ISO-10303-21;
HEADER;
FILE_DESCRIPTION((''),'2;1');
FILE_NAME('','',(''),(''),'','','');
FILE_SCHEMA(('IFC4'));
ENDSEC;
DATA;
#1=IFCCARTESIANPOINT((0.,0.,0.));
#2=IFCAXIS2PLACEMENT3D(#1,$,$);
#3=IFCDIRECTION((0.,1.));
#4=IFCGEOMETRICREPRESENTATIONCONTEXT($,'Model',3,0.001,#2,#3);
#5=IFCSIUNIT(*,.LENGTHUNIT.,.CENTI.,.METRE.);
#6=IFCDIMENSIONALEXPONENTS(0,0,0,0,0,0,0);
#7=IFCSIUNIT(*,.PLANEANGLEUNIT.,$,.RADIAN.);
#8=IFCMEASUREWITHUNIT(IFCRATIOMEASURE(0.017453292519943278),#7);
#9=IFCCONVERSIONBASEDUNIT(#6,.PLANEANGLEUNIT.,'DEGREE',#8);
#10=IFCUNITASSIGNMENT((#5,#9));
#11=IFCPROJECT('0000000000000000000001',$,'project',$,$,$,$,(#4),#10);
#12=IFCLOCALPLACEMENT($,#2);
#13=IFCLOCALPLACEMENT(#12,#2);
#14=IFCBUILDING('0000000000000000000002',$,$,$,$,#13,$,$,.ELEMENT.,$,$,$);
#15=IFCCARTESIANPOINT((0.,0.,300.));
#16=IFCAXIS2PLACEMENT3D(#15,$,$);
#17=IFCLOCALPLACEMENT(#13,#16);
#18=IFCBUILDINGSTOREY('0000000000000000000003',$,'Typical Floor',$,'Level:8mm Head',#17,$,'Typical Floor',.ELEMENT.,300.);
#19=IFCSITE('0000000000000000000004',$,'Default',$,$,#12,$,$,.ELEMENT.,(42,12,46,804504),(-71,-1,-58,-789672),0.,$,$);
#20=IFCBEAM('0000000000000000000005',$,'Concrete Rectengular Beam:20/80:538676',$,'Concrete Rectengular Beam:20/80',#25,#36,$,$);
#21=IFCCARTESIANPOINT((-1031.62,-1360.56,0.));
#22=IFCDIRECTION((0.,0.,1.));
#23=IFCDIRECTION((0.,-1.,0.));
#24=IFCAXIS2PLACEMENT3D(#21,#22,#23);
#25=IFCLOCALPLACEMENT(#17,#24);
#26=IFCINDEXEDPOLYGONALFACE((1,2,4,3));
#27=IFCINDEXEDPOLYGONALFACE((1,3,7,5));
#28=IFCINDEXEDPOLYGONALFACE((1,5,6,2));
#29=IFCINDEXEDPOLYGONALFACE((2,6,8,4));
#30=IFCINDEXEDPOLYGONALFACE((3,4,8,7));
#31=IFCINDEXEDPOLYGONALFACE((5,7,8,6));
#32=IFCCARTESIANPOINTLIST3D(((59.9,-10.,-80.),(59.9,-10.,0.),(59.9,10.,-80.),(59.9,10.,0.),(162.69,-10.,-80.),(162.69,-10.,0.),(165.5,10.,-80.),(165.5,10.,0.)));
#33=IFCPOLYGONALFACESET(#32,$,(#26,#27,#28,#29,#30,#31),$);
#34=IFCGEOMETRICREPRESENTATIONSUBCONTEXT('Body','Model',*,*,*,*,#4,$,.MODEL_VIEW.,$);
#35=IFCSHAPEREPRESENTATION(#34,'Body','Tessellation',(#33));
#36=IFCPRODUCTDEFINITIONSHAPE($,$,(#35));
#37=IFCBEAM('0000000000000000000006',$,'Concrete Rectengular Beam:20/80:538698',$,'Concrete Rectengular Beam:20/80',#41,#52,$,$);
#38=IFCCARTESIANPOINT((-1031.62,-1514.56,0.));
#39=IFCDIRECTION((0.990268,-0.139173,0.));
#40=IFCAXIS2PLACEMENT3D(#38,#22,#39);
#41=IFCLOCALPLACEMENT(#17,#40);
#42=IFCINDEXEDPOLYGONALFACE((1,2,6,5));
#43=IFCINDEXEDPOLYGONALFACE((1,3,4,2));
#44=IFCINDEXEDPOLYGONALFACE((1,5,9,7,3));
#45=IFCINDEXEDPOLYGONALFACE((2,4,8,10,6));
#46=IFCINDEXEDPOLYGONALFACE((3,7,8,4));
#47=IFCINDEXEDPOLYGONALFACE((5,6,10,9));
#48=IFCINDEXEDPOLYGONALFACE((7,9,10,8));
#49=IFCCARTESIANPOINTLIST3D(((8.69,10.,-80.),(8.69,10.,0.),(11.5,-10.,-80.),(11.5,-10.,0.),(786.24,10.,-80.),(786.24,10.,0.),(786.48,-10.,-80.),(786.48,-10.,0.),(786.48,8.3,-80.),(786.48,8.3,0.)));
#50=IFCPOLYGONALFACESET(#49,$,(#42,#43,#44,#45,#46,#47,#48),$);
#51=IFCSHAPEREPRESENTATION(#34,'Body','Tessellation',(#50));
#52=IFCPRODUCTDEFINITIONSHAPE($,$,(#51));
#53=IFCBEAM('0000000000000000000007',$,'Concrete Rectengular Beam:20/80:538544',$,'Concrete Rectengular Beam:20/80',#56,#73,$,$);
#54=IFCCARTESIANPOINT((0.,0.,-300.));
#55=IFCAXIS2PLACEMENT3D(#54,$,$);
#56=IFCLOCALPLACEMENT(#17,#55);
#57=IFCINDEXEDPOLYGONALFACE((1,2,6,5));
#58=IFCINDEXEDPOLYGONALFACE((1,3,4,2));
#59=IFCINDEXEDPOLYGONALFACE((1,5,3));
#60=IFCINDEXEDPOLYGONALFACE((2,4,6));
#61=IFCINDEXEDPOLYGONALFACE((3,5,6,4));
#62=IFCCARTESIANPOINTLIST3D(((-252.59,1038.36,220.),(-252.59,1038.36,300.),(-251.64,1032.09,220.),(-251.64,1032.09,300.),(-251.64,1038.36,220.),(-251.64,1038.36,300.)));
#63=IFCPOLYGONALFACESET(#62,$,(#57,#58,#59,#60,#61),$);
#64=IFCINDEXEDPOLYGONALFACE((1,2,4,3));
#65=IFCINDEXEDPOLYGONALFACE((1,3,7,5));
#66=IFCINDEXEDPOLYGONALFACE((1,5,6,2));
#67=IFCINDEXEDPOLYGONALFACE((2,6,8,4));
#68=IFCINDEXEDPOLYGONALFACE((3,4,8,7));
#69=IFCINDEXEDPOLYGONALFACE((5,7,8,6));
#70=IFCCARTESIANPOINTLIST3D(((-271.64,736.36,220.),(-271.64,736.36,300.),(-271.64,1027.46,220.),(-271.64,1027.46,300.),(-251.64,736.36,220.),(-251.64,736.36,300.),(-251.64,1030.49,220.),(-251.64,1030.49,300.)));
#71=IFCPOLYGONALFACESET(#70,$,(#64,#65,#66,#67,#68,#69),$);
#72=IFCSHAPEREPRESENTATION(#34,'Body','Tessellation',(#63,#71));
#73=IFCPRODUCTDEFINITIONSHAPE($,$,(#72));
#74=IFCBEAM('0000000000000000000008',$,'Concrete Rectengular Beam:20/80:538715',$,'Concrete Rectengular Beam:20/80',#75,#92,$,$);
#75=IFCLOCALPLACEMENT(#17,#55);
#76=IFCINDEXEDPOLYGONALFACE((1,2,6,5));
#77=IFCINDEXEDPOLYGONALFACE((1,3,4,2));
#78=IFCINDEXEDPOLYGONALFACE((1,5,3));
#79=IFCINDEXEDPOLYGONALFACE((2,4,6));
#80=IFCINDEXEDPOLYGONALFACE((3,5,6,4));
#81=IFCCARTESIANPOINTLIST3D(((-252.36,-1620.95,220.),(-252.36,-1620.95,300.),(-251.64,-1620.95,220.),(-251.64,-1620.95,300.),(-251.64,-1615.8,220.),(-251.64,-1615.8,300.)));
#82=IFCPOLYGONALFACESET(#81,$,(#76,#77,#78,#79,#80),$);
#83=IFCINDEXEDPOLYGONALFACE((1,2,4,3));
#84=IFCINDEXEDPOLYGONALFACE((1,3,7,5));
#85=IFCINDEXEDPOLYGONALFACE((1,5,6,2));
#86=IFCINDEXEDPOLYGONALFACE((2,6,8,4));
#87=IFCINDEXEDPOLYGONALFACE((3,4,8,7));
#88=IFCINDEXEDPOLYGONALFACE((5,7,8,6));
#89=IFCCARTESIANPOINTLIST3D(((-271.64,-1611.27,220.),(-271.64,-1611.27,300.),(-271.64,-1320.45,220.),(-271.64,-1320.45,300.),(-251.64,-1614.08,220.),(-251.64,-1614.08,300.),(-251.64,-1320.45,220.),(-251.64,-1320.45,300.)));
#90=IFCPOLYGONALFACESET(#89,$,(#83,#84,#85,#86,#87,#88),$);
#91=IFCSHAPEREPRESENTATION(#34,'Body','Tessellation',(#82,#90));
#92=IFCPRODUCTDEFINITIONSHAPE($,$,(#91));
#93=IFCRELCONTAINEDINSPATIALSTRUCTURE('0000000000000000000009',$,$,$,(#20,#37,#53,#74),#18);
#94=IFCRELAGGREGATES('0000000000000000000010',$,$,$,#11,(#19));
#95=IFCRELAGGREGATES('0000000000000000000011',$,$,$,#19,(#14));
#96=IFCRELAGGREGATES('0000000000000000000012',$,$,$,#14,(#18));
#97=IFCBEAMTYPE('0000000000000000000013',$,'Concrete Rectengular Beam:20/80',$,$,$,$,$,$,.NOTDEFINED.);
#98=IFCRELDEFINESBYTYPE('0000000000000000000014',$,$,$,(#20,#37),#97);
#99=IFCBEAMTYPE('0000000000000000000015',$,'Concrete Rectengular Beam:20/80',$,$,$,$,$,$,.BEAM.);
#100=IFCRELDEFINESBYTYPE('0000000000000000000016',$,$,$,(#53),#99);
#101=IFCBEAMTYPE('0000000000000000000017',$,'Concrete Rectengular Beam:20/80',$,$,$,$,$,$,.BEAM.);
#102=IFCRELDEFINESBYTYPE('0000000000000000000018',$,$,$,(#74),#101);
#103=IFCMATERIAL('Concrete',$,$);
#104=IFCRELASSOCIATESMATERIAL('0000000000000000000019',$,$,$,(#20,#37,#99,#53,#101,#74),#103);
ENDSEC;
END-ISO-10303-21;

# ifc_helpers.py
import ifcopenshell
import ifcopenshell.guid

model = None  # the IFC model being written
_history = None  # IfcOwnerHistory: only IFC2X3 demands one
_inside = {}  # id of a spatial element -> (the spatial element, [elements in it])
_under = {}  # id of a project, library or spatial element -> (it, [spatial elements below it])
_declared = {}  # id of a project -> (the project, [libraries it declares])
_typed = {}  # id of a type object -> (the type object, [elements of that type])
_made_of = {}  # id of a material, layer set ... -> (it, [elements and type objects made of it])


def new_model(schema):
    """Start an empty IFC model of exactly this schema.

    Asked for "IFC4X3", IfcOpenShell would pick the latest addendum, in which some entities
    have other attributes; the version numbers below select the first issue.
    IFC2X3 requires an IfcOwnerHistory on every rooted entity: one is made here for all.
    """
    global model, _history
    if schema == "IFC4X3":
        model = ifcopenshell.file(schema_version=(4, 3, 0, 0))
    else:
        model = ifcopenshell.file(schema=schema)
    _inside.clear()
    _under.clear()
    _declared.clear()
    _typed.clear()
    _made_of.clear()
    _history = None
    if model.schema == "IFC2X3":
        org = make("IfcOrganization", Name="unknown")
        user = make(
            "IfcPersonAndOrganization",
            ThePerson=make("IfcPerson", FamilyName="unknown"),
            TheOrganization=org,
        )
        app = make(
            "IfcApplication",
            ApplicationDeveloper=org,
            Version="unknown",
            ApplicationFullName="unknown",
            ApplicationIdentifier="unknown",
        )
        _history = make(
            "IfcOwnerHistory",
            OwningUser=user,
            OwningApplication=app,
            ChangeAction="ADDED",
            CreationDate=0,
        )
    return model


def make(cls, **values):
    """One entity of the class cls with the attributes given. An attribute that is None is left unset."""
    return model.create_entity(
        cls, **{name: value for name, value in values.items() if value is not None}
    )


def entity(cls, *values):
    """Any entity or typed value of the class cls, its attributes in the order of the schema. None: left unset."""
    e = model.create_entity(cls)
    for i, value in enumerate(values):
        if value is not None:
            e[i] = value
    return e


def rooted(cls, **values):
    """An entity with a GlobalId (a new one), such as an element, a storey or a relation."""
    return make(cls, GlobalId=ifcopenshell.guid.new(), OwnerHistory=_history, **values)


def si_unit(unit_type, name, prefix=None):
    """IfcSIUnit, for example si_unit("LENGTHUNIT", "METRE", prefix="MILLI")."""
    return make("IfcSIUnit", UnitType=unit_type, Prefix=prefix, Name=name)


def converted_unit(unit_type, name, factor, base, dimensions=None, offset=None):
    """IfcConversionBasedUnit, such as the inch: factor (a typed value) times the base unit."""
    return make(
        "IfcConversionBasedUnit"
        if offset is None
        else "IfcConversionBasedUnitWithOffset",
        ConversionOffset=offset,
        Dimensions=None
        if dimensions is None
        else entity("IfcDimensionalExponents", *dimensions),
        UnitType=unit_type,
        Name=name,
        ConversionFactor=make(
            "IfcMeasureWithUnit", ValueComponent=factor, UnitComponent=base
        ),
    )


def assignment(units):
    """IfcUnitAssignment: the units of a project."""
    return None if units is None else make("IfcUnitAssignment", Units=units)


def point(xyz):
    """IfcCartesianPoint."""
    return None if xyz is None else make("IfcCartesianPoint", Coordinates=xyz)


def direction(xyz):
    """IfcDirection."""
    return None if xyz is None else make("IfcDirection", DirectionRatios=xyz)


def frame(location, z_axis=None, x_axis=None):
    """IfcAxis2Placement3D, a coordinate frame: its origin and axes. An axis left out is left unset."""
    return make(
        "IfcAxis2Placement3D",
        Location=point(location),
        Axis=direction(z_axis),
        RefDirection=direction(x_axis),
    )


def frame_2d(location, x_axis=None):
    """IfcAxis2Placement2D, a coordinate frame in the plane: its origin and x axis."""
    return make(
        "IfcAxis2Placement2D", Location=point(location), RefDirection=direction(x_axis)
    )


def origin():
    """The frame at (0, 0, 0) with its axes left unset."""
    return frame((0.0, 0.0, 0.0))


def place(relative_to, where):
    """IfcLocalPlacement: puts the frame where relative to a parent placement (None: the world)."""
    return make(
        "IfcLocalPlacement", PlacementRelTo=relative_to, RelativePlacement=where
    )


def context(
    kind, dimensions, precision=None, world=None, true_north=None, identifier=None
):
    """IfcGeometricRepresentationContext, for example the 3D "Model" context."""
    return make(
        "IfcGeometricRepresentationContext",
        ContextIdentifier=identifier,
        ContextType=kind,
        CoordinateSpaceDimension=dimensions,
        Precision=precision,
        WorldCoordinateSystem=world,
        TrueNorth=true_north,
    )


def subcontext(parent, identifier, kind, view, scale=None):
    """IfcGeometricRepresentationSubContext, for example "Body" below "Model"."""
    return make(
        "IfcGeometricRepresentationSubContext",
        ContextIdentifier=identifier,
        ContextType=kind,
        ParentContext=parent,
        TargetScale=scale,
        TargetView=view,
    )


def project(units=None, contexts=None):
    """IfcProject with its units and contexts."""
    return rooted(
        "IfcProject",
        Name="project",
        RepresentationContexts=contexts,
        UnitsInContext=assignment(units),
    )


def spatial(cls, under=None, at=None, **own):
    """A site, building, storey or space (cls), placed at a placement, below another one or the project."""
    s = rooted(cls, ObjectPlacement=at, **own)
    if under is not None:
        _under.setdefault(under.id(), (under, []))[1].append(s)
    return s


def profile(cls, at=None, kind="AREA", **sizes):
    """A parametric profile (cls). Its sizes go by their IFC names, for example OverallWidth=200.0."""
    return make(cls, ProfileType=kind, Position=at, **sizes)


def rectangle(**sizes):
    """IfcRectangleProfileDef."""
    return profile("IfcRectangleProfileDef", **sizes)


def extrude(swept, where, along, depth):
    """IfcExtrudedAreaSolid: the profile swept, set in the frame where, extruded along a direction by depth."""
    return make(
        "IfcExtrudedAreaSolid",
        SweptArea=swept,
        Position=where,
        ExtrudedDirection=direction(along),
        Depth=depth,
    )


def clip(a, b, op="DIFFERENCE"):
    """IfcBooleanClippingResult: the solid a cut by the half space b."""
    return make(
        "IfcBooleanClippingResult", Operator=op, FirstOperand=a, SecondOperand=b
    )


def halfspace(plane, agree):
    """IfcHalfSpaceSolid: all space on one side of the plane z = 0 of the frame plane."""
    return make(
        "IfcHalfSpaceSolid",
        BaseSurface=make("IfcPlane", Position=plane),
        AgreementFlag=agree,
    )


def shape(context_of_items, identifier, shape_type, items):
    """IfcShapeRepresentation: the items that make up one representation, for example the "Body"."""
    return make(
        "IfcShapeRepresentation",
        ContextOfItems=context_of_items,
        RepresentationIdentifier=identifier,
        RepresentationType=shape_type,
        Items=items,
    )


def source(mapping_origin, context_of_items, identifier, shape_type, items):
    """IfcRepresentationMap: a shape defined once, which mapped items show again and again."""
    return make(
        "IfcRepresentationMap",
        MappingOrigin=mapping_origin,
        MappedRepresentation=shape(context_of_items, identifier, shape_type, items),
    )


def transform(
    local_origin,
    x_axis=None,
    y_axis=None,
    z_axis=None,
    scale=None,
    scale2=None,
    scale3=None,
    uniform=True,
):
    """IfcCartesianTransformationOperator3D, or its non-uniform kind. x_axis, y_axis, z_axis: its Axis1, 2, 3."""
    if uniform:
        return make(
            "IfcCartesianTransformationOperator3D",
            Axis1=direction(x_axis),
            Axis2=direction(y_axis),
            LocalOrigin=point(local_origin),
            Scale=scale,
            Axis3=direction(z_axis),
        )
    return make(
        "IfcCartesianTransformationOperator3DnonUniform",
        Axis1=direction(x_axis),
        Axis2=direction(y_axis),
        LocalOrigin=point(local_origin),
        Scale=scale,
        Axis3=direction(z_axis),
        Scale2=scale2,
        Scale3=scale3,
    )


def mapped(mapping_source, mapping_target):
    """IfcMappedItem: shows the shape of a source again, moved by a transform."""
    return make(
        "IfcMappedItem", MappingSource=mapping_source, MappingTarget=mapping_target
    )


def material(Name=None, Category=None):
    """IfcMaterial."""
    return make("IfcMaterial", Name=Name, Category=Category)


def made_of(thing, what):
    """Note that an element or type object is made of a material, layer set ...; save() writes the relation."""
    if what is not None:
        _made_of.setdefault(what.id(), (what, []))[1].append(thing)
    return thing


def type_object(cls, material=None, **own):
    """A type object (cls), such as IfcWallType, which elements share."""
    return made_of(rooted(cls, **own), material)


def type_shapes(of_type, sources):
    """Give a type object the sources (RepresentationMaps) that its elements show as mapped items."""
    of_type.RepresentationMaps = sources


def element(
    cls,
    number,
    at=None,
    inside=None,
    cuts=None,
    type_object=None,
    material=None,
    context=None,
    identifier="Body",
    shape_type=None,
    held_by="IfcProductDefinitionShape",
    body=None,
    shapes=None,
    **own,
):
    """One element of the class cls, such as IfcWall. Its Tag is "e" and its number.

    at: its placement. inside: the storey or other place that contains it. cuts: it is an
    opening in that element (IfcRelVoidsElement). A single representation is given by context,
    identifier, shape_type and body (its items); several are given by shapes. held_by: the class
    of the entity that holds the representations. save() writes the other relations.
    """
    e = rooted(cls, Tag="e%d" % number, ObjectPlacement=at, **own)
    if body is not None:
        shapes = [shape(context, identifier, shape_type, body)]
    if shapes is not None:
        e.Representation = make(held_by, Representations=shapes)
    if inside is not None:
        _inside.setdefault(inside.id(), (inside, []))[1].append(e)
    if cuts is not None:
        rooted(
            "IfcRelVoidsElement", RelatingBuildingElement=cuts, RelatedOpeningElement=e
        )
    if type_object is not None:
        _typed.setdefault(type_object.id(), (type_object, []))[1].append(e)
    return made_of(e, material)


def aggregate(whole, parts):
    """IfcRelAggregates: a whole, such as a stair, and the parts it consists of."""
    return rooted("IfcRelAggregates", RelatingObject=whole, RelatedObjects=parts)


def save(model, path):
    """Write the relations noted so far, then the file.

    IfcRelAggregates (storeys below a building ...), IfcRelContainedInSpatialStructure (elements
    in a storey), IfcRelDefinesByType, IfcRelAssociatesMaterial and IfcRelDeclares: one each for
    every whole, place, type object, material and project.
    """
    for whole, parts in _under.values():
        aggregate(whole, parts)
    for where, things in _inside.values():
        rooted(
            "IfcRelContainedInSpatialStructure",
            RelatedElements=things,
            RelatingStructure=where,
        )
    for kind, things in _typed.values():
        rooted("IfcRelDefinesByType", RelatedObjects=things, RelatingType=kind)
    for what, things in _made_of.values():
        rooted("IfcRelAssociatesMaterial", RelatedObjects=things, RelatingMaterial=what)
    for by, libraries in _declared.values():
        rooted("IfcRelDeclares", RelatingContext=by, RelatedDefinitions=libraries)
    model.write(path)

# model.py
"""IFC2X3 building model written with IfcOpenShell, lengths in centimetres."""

from ifc_helpers import new_model, entity, si_unit, converted_unit, direction, frame, frame_2d, origin, place, context, subcontext, project, spatial, rectangle, extrude, clip, halfspace, source, transform, mapped, material, type_object, type_shapes, element, save


model = new_model("IFC2X3")

# Units and contexts
model_context = context("Model", 3, precision=0.001, world=origin(), true_north=direction((0.0, 1.0)))
body_context = subcontext(model_context, "Body", "Model", "MODEL_VIEW")
ifc_project = project(units=[si_unit("LENGTHUNIT", "METRE", prefix="CENTI"), converted_unit("PLANEANGLEUNIT", "DEGREE", entity("IfcRatioMeasure", 0.017453292519943278), si_unit("PLANEANGLEUNIT", "RADIAN"), dimensions=[0, 0, 0, 0, 0, 0, 0])], contexts=[model_context])

# Site, building, storey
site_placement = place(None, origin())
site = spatial("IfcSite", under=ifc_project, at=site_placement, Name="Default", CompositionType="ELEMENT", RefLatitude=(42, 12, 46, 804504), RefLongitude=(-71, -1, -58, -789672), RefElevation=0.0)
building_placement = place(site_placement, origin())
building = spatial("IfcBuilding", under=site, at=building_placement, CompositionType="ELEMENT")
storey_placement = place(building_placement, frame((0.0, 0.0, 300.0)))
storey = spatial("IfcBuildingStorey", under=building, at=storey_placement, Name="Typical Floor", ObjectType="Level:8mm Head", LongName="Typical Floor", CompositionType="ELEMENT", Elevation=300.0)

# Beams
ifc_material = material(Name="Concrete")
beam_type_1 = type_object("IfcBeamType", Name="Concrete Rectengular Beam:20/80", PredefinedType="NOTDEFINED")
beam_1_placement = place(storey_placement, frame((-1031.62, -1360.56, 0.0), z_axis=(0.0, 0.0, 1.0), x_axis=(0.0, -1.0, 0.0)))
element("IfcBeam", 1, at=beam_1_placement, inside=storey, type_object=beam_type_1, material=ifc_material, Name="Concrete Rectengular Beam:20/80:538676", ObjectType="Concrete Rectengular Beam:20/80", context=body_context, shape_type="SweptSolid", body=[
    clip(extrude(rectangle(XDim=80.0, YDim=20.0, at=frame_2d((0.0, 0.0), x_axis=(1.0, 0.0))), frame((59.9, 0.0, -40.0), z_axis=(1.0, 0.0, 0.0), x_axis=(0.0, 0.0, -1.0)), (0.0, 0.0, 1.0), 105.61), halfspace(frame((162.13, -14.02, -80.0), z_axis=(0.990268, -0.139173, 0.0), x_axis=(0.139173, 0.990268, 0.0)), False)),
])
beam_2_placement = place(storey_placement, frame((-1031.62, -1514.56, 0.0), z_axis=(0.0, 0.0, 1.0), x_axis=(0.990268, -0.139173, 0.0)))
element("IfcBeam", 2, at=beam_2_placement, inside=storey, type_object=beam_type_1, material=ifc_material, Name="Concrete Rectengular Beam:20/80:538698", ObjectType="Concrete Rectengular Beam:20/80", context=body_context, shape_type="SweptSolid", body=[
    clip(clip(extrude(rectangle(XDim=80.0, YDim=20.0, at=frame_2d((0.0, 0.0), x_axis=(1.0, 0.0))), frame((8.69, 0.0, -40.0), z_axis=(1.0, 0.0, 0.0), x_axis=(0.0, 0.0, -1.0)), (0.0, 0.0, 1.0), 777.79), halfspace(frame((8.35, 12.46, -80.0), z_axis=(-0.990268, -0.139173, 0.0), x_axis=(-0.139173, 0.990268, 0.0)), False)), halfspace(frame((789.33, -11.99, -80.0), z_axis=(0.990268, 0.139173, 0.0), x_axis=(-0.139173, 0.990268, 0.0)), False)),
])
beam_type_2 = type_object("IfcBeamType", Name="Concrete Rectengular Beam:20/80", PredefinedType="BEAM", material=ifc_material)
shared_shape_1 = source(origin(), body_context, "Body", "SweptSolid", [
    clip(extrude(rectangle(XDim=80.0, YDim=0.95, at=frame_2d((0.0, 0.0), x_axis=(0.0, 1.0))), frame((-252.11, 1038.36, 260.0), z_axis=(0.0, -1.0, 0.0), x_axis=(-1.0, 0.0, 0.0)), (0.0, 0.0, 1.0), 6.27), halfspace(frame((-252.9, 1040.41, 260.0), z_axis=(-0.988733, -0.14969, 0.0), x_axis=(0.14969, -0.988733, 0.0)), False)),
    clip(extrude(rectangle(XDim=80.0, YDim=20.0, at=frame_2d((0.0, 0.0), x_axis=(0.0, 1.0))), frame((-261.64, 1030.49, 260.0), z_axis=(0.0, -1.0, 0.0), x_axis=(-1.0, 0.0, 0.0)), (0.0, 0.0, 1.0), 294.13), halfspace(frame((-272.89, 1027.27, 300.0), z_axis=(-0.14969, 0.988733, 0.0), x_axis=(-0.988733, -0.14969, 0.0)), False)),
])
type_shapes(beam_type_2, [shared_shape_1])
beam_3_placement = place(storey_placement, frame((0.0, 0.0, -300.0)))
element("IfcBeam", 3, at=beam_3_placement, inside=storey, type_object=beam_type_2, material=ifc_material, Name="Concrete Rectengular Beam:20/80:538544", ObjectType="Concrete Rectengular Beam:20/80", context=body_context, shape_type="MappedRepresentation", body=[
    mapped(shared_shape_1, transform((0.0, 0.0, 0.0), scale=1.0)),
])
beam_type_3 = type_object("IfcBeamType", Name="Concrete Rectengular Beam:20/80", PredefinedType="BEAM", material=ifc_material)
shared_shape_2 = source(origin(), body_context, "Body", "SweptSolid", [
    clip(extrude(rectangle(XDim=80.0, YDim=0.72, at=frame_2d((0.0, 0.0), x_axis=(0.0, 1.0))), frame((-252.0, -1620.95, 260.0), z_axis=(0.0, 1.0, 0.0), x_axis=(-1.0, 0.0, 0.0)), (0.0, 0.0, 1.0), 5.15), halfspace(frame((-252.79, -1624.01, 260.0), z_axis=(-0.990268, 0.139173, 0.0), x_axis=(0.139173, 0.990268, 0.0)), False)),
    clip(extrude(rectangle(XDim=80.0, YDim=20.0, at=frame_2d((0.0, 0.0), x_axis=(0.0, 1.0))), frame((-261.64, -1614.08, 260.0), z_axis=(0.0, 1.0, 0.0), x_axis=(-1.0, 0.0, 0.0)), (0.0, 0.0, 1.0), 293.63), halfspace(frame((-272.9, -1611.09, 220.0), z_axis=(-0.139173, -0.990268, 0.0), x_axis=(-0.990268, 0.139173, 0.0)), False)),
])
type_shapes(beam_type_3, [shared_shape_2])
beam_4_placement = place(storey_placement, frame((0.0, 0.0, -300.0)))
element("IfcBeam", 4, at=beam_4_placement, inside=storey, type_object=beam_type_3, material=ifc_material, Name="Concrete Rectengular Beam:20/80:538715", ObjectType="Concrete Rectengular Beam:20/80", context=body_context, shape_type="MappedRepresentation", body=[
    mapped(shared_shape_2, transform((0.0, 0.0, 0.0), scale=1.0)),
])

save(model, "model.ifc")
